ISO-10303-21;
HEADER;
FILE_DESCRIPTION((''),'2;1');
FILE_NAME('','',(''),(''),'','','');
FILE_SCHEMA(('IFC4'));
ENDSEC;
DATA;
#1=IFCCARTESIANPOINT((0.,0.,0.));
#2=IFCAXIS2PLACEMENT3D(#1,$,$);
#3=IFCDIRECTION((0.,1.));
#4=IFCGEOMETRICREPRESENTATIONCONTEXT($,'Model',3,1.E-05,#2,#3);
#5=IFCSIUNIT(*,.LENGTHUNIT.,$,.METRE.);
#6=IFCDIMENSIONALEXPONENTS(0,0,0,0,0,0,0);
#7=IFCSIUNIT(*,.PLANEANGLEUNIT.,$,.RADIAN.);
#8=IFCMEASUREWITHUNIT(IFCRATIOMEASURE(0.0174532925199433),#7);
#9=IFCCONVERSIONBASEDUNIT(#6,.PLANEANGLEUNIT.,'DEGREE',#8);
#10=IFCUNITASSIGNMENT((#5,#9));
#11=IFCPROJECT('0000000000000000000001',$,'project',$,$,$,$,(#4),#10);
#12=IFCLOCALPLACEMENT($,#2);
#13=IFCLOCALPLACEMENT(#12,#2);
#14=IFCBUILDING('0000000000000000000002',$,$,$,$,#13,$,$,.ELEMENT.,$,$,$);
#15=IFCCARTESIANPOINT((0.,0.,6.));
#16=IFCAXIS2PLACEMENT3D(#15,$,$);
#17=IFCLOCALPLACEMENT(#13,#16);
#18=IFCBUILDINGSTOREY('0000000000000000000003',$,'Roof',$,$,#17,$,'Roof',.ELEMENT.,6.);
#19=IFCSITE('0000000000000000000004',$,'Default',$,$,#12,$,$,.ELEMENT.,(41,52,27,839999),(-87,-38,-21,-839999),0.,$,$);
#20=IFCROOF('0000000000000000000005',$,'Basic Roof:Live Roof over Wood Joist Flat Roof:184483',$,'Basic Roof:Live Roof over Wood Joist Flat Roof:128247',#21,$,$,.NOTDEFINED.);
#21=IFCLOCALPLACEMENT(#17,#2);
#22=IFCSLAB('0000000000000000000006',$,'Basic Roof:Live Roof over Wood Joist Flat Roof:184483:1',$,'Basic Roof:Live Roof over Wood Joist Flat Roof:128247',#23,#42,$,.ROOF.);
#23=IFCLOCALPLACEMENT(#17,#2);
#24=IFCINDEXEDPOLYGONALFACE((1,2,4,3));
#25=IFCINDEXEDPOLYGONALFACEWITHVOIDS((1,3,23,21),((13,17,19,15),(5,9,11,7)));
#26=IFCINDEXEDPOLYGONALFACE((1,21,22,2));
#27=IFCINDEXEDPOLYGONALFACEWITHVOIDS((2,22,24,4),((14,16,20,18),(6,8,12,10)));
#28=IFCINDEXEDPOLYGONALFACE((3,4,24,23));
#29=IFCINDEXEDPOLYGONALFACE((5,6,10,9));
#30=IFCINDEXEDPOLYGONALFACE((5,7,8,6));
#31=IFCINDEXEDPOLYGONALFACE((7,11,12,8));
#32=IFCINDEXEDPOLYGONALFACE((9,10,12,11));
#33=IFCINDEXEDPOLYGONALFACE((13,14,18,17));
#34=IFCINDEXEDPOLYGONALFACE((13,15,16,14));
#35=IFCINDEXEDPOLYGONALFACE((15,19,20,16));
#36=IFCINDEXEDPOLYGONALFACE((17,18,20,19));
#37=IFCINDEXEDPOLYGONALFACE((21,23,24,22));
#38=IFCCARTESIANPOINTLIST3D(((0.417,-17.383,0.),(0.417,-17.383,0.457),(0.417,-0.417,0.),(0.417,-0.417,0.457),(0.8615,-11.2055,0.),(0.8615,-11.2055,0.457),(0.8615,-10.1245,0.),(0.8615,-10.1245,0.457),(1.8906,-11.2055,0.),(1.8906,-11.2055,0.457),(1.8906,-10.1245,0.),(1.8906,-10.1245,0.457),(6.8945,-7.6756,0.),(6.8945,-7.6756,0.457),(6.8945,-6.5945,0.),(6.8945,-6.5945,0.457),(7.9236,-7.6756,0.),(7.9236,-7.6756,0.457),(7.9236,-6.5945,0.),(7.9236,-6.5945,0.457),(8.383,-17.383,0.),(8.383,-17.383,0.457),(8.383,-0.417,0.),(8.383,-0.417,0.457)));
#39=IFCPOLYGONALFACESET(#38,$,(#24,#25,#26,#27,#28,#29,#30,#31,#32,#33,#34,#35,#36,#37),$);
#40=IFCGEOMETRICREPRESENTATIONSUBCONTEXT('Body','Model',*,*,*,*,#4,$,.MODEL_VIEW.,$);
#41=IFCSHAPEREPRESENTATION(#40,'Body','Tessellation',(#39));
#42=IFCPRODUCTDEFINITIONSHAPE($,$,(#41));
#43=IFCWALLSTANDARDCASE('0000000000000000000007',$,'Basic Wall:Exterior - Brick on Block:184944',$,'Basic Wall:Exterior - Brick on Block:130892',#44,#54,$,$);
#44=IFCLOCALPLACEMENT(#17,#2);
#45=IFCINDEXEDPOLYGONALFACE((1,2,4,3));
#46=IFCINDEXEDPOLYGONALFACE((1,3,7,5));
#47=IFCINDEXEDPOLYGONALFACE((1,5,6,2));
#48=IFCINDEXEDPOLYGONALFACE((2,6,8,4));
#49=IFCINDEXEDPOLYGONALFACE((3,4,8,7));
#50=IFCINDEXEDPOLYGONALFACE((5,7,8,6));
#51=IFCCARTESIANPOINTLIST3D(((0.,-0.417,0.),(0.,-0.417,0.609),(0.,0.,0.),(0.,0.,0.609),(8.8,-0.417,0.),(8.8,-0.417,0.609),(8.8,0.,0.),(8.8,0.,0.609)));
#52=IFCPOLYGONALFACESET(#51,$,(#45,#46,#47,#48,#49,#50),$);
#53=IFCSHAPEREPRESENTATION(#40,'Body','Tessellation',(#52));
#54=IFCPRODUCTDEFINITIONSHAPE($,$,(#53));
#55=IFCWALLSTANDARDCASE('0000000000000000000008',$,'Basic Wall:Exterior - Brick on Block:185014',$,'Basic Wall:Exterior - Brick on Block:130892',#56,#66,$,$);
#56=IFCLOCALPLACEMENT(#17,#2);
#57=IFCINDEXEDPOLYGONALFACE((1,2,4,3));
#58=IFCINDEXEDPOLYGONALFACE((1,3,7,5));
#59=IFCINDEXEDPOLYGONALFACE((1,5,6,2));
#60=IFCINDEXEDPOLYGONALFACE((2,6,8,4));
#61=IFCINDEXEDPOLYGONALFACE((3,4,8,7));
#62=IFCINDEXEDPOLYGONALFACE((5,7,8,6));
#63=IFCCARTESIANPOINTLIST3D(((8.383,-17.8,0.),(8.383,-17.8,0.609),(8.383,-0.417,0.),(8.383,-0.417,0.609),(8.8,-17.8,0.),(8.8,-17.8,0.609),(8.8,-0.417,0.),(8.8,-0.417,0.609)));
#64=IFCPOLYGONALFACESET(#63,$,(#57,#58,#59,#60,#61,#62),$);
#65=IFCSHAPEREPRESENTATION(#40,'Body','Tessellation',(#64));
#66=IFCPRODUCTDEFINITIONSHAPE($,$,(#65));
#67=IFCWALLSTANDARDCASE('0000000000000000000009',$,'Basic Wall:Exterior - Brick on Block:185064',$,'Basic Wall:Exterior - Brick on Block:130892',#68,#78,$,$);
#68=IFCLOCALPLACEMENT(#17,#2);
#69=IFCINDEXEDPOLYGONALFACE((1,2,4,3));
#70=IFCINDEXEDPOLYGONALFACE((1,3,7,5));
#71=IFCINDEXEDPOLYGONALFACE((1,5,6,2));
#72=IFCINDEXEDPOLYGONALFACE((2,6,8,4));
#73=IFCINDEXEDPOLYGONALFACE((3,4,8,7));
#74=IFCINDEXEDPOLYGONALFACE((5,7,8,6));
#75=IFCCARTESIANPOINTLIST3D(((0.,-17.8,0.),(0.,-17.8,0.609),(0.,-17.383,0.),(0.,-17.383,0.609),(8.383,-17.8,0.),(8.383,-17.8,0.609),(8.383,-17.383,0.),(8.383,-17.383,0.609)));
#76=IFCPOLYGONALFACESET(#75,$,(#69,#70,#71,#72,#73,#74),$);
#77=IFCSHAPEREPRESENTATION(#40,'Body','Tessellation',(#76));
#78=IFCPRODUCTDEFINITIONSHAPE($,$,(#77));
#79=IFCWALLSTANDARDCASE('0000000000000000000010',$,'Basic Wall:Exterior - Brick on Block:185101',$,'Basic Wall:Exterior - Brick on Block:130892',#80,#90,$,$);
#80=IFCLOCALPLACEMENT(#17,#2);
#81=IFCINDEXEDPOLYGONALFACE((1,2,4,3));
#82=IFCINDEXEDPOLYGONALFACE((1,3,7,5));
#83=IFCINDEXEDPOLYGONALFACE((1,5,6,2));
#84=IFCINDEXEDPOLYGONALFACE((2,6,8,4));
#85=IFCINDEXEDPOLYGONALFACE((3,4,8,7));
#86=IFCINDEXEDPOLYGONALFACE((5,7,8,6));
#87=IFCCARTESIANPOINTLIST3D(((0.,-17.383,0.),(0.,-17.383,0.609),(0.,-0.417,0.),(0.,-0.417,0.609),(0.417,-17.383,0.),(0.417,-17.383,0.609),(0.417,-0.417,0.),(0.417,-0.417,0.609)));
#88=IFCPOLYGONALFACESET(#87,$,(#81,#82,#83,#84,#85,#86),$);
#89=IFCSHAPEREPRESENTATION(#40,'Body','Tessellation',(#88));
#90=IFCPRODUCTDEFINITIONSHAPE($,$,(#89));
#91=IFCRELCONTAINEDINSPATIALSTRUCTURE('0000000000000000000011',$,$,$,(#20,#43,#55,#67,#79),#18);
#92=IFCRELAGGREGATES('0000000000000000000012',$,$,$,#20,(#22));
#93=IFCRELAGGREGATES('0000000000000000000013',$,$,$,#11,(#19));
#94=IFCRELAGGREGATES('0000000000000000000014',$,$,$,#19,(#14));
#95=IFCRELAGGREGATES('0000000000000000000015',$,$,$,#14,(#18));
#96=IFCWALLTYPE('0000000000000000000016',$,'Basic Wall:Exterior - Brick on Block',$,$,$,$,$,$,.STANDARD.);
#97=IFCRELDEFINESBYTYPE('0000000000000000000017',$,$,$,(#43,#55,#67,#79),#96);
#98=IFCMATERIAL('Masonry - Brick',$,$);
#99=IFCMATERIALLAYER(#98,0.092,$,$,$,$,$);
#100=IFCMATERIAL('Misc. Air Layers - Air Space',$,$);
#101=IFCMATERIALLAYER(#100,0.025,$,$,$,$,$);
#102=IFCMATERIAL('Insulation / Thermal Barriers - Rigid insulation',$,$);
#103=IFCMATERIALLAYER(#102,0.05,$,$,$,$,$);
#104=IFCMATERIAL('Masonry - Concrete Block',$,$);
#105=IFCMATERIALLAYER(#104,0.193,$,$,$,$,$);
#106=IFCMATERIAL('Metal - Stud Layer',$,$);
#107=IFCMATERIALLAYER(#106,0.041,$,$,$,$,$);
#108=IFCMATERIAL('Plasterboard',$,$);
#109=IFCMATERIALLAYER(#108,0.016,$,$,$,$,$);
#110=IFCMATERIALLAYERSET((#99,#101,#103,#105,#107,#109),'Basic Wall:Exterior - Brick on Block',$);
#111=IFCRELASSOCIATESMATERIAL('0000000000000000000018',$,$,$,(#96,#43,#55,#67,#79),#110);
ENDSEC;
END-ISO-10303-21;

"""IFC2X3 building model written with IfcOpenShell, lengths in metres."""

from ifc_helpers import new_model, entity, si_unit, converted_unit, direction, frame, frame_2d, origin, place, context, subcontext, project, spatial, rectangle, extrude, material, layer, layer_set, layer_usage, type_object, element, aggregate, save


model = new_model("IFC2X3")

# Units and contexts
model_context = context("Model", 3, precision=1e-05, world=origin(), true_north=direction((0.0, 1.0)))
body_context = subcontext(model_context, "Body", "Model", "MODEL_VIEW")
ifc_project = project(units=[si_unit("LENGTHUNIT", "METRE"), converted_unit("PLANEANGLEUNIT", "DEGREE", entity("IfcRatioMeasure", 0.0174532925199433), si_unit("PLANEANGLEUNIT", "RADIAN"), dimensions=[0, 0, 0, 0, 0, 0, 0])], contexts=[model_context])

# Site, building, storey
site_placement = place(None, origin())
site = spatial("IfcSite", under=ifc_project, at=site_placement, Name="Default", CompositionType="ELEMENT", RefLatitude=(41, 52, 27, 839999), RefLongitude=(-87, -38, -21, -839999), RefElevation=0.0)
building_placement = place(site_placement, origin())
building = spatial("IfcBuilding", under=site, at=building_placement, CompositionType="ELEMENT")
storey_placement = place(building_placement, frame((0.0, 0.0, 6.0)))
storey = spatial("IfcBuildingStorey", under=building, at=storey_placement, Name="Roof", LongName="Roof", CompositionType="ELEMENT", Elevation=6.0)

# Roof, slab, openings
roof_placement = place(storey_placement, origin())
roof = element("IfcRoof", 1, at=roof_placement, inside=storey, Name="Basic Roof:Live Roof over Wood Joist Flat Roof:184483", ObjectType="Basic Roof:Live Roof over Wood Joist Flat Roof:128247", ShapeType="NOTDEFINED")
slab_placement = place(storey_placement, origin())
slab = element("IfcSlab", 2, at=slab_placement, Name="Basic Roof:Live Roof over Wood Joist Flat Roof:184483:1", ObjectType="Basic Roof:Live Roof over Wood Joist Flat Roof:128247", PredefinedType="ROOF", context=body_context, shape_type="SweptSolid", body=[
    extrude(rectangle(XDim=16.966, YDim=7.966, at=frame_2d((0.0, 0.0), x_axis=(1.0, 0.0))), frame((4.4, -8.9, 0.0), z_axis=(0.0, 0.0, 1.0), x_axis=(0.0, -1.0, 0.0)), (0.0, 0.0, 1.0), 0.457),
])
opening_1_placement = place(storey_placement, origin())
element("IfcOpeningElement", 3, at=opening_1_placement, cuts=slab, ObjectType="Opening", context=body_context, shape_type="SweptSolid", body=[
    extrude(rectangle(XDim=1.0291, YDim=1.0811, at=frame_2d((0.0, 0.0), x_axis=(1.0, 0.0))), frame((1.376, -10.665, 0.0), z_axis=(0.0, 0.0, 1.0), x_axis=(-1.0, 0.0, 0.0)), (0.0, 0.0, 1.0), 0.457),
])
opening_2_placement = place(storey_placement, origin())
element("IfcOpeningElement", 4, at=opening_2_placement, cuts=slab, ObjectType="Opening", context=body_context, shape_type="SweptSolid", body=[
    extrude(rectangle(XDim=1.0291, YDim=1.0811, at=frame_2d((0.0, 0.0), x_axis=(1.0, 0.0))), frame((7.409, -7.135, 0.0), z_axis=(0.0, 0.0, 1.0), x_axis=(-1.0, 0.0, 0.0)), (0.0, 0.0, 1.0), 0.457),
])
aggregate(roof, [slab])

# Walls
ifc_material_1 = material(Name="Masonry - Brick")
ifc_layer_1 = layer(ifc_material_1, 0.092)
ifc_material_2 = material(Name="Misc. Air Layers - Air Space")
ifc_layer_2 = layer(ifc_material_2, 0.025)
ifc_material_3 = material(Name="Insulation / Thermal Barriers - Rigid insulation")
ifc_layer_3 = layer(ifc_material_3, 0.05)
ifc_material_4 = material(Name="Masonry - Concrete Block")
ifc_layer_4 = layer(ifc_material_4, 0.193)
ifc_material_5 = material(Name="Metal - Stud Layer")
ifc_layer_5 = layer(ifc_material_5, 0.041)
ifc_material_6 = material(Name="Plasterboard")
ifc_layer_6 = layer(ifc_material_6, 0.016)
ifc_layer_set = layer_set([ifc_layer_1, ifc_layer_2, ifc_layer_3, ifc_layer_4, ifc_layer_5, ifc_layer_6], Name="Basic Wall:Exterior - Brick on Block")
ifc_layer_usage_1 = layer_usage(ifc_layer_set, "AXIS2", "NEGATIVE", 0.2085)
wall_type = type_object("IfcWallType", Name="Basic Wall:Exterior - Brick on Block", PredefinedType="STANDARD", material=ifc_layer_set)
wall_1_placement = place(storey_placement, frame((0.0, -0.2085, 0.0)))
element("IfcWallStandardCase", 5, at=wall_1_placement, inside=storey, type_object=wall_type, material=ifc_layer_usage_1, Name="Basic Wall:Exterior - Brick on Block:184944", ObjectType="Basic Wall:Exterior - Brick on Block:130892", context=body_context, shape_type="SweptSolid", body=[
    extrude(rectangle(XDim=8.8, YDim=0.417, at=frame_2d((4.4, 0.0), x_axis=(-1.0, 0.0))), origin(), (0.0, 0.0, 1.0), 0.609),
])
ifc_layer_usage_2 = layer_usage(ifc_layer_set, "AXIS2", "NEGATIVE", 0.2085)
wall_2_placement = place(storey_placement, frame((8.5915, -0.417, 0.0), z_axis=(0.0, 0.0, 1.0), x_axis=(0.0, -1.0, 0.0)))
element("IfcWallStandardCase", 6, at=wall_2_placement, inside=storey, type_object=wall_type, material=ifc_layer_usage_2, Name="Basic Wall:Exterior - Brick on Block:185014", ObjectType="Basic Wall:Exterior - Brick on Block:130892", context=body_context, shape_type="SweptSolid", body=[
    extrude(rectangle(XDim=17.383, YDim=0.417, at=frame_2d((8.6915, 0.0), x_axis=(-1.0, 0.0))), origin(), (0.0, 0.0, 1.0), 0.609),
])
ifc_layer_usage_3 = layer_usage(ifc_layer_set, "AXIS2", "NEGATIVE", 0.2085)
wall_3_placement = place(storey_placement, frame((8.383, -17.5915, 0.0), z_axis=(0.0, 0.0, 1.0), x_axis=(-1.0, 0.0, 0.0)))
element("IfcWallStandardCase", 7, at=wall_3_placement, inside=storey, type_object=wall_type, material=ifc_layer_usage_3, Name="Basic Wall:Exterior - Brick on Block:185064", ObjectType="Basic Wall:Exterior - Brick on Block:130892", context=body_context, shape_type="SweptSolid", body=[
    extrude(rectangle(XDim=8.383, YDim=0.417, at=frame_2d((4.1915, 0.0), x_axis=(-1.0, 0.0))), origin(), (0.0, 0.0, 1.0), 0.609),
])
ifc_layer_usage_4 = layer_usage(ifc_layer_set, "AXIS2", "NEGATIVE", 0.2085)
wall_4_placement = place(storey_placement, frame((0.2085, -17.383, 0.0), z_axis=(0.0, 0.0, 1.0), x_axis=(0.0, 1.0, 0.0)))
element("IfcWallStandardCase", 8, at=wall_4_placement, inside=storey, type_object=wall_type, material=ifc_layer_usage_4, Name="Basic Wall:Exterior - Brick on Block:185101", ObjectType="Basic Wall:Exterior - Brick on Block:130892", context=body_context, shape_type="SweptSolid", body=[
    extrude(rectangle(XDim=16.966, YDim=0.417, at=frame_2d((8.483, 0.0), x_axis=(-1.0, 0.0))), origin(), (0.0, 0.0, 1.0), 0.609),
])

save(model, "model.ifc")
